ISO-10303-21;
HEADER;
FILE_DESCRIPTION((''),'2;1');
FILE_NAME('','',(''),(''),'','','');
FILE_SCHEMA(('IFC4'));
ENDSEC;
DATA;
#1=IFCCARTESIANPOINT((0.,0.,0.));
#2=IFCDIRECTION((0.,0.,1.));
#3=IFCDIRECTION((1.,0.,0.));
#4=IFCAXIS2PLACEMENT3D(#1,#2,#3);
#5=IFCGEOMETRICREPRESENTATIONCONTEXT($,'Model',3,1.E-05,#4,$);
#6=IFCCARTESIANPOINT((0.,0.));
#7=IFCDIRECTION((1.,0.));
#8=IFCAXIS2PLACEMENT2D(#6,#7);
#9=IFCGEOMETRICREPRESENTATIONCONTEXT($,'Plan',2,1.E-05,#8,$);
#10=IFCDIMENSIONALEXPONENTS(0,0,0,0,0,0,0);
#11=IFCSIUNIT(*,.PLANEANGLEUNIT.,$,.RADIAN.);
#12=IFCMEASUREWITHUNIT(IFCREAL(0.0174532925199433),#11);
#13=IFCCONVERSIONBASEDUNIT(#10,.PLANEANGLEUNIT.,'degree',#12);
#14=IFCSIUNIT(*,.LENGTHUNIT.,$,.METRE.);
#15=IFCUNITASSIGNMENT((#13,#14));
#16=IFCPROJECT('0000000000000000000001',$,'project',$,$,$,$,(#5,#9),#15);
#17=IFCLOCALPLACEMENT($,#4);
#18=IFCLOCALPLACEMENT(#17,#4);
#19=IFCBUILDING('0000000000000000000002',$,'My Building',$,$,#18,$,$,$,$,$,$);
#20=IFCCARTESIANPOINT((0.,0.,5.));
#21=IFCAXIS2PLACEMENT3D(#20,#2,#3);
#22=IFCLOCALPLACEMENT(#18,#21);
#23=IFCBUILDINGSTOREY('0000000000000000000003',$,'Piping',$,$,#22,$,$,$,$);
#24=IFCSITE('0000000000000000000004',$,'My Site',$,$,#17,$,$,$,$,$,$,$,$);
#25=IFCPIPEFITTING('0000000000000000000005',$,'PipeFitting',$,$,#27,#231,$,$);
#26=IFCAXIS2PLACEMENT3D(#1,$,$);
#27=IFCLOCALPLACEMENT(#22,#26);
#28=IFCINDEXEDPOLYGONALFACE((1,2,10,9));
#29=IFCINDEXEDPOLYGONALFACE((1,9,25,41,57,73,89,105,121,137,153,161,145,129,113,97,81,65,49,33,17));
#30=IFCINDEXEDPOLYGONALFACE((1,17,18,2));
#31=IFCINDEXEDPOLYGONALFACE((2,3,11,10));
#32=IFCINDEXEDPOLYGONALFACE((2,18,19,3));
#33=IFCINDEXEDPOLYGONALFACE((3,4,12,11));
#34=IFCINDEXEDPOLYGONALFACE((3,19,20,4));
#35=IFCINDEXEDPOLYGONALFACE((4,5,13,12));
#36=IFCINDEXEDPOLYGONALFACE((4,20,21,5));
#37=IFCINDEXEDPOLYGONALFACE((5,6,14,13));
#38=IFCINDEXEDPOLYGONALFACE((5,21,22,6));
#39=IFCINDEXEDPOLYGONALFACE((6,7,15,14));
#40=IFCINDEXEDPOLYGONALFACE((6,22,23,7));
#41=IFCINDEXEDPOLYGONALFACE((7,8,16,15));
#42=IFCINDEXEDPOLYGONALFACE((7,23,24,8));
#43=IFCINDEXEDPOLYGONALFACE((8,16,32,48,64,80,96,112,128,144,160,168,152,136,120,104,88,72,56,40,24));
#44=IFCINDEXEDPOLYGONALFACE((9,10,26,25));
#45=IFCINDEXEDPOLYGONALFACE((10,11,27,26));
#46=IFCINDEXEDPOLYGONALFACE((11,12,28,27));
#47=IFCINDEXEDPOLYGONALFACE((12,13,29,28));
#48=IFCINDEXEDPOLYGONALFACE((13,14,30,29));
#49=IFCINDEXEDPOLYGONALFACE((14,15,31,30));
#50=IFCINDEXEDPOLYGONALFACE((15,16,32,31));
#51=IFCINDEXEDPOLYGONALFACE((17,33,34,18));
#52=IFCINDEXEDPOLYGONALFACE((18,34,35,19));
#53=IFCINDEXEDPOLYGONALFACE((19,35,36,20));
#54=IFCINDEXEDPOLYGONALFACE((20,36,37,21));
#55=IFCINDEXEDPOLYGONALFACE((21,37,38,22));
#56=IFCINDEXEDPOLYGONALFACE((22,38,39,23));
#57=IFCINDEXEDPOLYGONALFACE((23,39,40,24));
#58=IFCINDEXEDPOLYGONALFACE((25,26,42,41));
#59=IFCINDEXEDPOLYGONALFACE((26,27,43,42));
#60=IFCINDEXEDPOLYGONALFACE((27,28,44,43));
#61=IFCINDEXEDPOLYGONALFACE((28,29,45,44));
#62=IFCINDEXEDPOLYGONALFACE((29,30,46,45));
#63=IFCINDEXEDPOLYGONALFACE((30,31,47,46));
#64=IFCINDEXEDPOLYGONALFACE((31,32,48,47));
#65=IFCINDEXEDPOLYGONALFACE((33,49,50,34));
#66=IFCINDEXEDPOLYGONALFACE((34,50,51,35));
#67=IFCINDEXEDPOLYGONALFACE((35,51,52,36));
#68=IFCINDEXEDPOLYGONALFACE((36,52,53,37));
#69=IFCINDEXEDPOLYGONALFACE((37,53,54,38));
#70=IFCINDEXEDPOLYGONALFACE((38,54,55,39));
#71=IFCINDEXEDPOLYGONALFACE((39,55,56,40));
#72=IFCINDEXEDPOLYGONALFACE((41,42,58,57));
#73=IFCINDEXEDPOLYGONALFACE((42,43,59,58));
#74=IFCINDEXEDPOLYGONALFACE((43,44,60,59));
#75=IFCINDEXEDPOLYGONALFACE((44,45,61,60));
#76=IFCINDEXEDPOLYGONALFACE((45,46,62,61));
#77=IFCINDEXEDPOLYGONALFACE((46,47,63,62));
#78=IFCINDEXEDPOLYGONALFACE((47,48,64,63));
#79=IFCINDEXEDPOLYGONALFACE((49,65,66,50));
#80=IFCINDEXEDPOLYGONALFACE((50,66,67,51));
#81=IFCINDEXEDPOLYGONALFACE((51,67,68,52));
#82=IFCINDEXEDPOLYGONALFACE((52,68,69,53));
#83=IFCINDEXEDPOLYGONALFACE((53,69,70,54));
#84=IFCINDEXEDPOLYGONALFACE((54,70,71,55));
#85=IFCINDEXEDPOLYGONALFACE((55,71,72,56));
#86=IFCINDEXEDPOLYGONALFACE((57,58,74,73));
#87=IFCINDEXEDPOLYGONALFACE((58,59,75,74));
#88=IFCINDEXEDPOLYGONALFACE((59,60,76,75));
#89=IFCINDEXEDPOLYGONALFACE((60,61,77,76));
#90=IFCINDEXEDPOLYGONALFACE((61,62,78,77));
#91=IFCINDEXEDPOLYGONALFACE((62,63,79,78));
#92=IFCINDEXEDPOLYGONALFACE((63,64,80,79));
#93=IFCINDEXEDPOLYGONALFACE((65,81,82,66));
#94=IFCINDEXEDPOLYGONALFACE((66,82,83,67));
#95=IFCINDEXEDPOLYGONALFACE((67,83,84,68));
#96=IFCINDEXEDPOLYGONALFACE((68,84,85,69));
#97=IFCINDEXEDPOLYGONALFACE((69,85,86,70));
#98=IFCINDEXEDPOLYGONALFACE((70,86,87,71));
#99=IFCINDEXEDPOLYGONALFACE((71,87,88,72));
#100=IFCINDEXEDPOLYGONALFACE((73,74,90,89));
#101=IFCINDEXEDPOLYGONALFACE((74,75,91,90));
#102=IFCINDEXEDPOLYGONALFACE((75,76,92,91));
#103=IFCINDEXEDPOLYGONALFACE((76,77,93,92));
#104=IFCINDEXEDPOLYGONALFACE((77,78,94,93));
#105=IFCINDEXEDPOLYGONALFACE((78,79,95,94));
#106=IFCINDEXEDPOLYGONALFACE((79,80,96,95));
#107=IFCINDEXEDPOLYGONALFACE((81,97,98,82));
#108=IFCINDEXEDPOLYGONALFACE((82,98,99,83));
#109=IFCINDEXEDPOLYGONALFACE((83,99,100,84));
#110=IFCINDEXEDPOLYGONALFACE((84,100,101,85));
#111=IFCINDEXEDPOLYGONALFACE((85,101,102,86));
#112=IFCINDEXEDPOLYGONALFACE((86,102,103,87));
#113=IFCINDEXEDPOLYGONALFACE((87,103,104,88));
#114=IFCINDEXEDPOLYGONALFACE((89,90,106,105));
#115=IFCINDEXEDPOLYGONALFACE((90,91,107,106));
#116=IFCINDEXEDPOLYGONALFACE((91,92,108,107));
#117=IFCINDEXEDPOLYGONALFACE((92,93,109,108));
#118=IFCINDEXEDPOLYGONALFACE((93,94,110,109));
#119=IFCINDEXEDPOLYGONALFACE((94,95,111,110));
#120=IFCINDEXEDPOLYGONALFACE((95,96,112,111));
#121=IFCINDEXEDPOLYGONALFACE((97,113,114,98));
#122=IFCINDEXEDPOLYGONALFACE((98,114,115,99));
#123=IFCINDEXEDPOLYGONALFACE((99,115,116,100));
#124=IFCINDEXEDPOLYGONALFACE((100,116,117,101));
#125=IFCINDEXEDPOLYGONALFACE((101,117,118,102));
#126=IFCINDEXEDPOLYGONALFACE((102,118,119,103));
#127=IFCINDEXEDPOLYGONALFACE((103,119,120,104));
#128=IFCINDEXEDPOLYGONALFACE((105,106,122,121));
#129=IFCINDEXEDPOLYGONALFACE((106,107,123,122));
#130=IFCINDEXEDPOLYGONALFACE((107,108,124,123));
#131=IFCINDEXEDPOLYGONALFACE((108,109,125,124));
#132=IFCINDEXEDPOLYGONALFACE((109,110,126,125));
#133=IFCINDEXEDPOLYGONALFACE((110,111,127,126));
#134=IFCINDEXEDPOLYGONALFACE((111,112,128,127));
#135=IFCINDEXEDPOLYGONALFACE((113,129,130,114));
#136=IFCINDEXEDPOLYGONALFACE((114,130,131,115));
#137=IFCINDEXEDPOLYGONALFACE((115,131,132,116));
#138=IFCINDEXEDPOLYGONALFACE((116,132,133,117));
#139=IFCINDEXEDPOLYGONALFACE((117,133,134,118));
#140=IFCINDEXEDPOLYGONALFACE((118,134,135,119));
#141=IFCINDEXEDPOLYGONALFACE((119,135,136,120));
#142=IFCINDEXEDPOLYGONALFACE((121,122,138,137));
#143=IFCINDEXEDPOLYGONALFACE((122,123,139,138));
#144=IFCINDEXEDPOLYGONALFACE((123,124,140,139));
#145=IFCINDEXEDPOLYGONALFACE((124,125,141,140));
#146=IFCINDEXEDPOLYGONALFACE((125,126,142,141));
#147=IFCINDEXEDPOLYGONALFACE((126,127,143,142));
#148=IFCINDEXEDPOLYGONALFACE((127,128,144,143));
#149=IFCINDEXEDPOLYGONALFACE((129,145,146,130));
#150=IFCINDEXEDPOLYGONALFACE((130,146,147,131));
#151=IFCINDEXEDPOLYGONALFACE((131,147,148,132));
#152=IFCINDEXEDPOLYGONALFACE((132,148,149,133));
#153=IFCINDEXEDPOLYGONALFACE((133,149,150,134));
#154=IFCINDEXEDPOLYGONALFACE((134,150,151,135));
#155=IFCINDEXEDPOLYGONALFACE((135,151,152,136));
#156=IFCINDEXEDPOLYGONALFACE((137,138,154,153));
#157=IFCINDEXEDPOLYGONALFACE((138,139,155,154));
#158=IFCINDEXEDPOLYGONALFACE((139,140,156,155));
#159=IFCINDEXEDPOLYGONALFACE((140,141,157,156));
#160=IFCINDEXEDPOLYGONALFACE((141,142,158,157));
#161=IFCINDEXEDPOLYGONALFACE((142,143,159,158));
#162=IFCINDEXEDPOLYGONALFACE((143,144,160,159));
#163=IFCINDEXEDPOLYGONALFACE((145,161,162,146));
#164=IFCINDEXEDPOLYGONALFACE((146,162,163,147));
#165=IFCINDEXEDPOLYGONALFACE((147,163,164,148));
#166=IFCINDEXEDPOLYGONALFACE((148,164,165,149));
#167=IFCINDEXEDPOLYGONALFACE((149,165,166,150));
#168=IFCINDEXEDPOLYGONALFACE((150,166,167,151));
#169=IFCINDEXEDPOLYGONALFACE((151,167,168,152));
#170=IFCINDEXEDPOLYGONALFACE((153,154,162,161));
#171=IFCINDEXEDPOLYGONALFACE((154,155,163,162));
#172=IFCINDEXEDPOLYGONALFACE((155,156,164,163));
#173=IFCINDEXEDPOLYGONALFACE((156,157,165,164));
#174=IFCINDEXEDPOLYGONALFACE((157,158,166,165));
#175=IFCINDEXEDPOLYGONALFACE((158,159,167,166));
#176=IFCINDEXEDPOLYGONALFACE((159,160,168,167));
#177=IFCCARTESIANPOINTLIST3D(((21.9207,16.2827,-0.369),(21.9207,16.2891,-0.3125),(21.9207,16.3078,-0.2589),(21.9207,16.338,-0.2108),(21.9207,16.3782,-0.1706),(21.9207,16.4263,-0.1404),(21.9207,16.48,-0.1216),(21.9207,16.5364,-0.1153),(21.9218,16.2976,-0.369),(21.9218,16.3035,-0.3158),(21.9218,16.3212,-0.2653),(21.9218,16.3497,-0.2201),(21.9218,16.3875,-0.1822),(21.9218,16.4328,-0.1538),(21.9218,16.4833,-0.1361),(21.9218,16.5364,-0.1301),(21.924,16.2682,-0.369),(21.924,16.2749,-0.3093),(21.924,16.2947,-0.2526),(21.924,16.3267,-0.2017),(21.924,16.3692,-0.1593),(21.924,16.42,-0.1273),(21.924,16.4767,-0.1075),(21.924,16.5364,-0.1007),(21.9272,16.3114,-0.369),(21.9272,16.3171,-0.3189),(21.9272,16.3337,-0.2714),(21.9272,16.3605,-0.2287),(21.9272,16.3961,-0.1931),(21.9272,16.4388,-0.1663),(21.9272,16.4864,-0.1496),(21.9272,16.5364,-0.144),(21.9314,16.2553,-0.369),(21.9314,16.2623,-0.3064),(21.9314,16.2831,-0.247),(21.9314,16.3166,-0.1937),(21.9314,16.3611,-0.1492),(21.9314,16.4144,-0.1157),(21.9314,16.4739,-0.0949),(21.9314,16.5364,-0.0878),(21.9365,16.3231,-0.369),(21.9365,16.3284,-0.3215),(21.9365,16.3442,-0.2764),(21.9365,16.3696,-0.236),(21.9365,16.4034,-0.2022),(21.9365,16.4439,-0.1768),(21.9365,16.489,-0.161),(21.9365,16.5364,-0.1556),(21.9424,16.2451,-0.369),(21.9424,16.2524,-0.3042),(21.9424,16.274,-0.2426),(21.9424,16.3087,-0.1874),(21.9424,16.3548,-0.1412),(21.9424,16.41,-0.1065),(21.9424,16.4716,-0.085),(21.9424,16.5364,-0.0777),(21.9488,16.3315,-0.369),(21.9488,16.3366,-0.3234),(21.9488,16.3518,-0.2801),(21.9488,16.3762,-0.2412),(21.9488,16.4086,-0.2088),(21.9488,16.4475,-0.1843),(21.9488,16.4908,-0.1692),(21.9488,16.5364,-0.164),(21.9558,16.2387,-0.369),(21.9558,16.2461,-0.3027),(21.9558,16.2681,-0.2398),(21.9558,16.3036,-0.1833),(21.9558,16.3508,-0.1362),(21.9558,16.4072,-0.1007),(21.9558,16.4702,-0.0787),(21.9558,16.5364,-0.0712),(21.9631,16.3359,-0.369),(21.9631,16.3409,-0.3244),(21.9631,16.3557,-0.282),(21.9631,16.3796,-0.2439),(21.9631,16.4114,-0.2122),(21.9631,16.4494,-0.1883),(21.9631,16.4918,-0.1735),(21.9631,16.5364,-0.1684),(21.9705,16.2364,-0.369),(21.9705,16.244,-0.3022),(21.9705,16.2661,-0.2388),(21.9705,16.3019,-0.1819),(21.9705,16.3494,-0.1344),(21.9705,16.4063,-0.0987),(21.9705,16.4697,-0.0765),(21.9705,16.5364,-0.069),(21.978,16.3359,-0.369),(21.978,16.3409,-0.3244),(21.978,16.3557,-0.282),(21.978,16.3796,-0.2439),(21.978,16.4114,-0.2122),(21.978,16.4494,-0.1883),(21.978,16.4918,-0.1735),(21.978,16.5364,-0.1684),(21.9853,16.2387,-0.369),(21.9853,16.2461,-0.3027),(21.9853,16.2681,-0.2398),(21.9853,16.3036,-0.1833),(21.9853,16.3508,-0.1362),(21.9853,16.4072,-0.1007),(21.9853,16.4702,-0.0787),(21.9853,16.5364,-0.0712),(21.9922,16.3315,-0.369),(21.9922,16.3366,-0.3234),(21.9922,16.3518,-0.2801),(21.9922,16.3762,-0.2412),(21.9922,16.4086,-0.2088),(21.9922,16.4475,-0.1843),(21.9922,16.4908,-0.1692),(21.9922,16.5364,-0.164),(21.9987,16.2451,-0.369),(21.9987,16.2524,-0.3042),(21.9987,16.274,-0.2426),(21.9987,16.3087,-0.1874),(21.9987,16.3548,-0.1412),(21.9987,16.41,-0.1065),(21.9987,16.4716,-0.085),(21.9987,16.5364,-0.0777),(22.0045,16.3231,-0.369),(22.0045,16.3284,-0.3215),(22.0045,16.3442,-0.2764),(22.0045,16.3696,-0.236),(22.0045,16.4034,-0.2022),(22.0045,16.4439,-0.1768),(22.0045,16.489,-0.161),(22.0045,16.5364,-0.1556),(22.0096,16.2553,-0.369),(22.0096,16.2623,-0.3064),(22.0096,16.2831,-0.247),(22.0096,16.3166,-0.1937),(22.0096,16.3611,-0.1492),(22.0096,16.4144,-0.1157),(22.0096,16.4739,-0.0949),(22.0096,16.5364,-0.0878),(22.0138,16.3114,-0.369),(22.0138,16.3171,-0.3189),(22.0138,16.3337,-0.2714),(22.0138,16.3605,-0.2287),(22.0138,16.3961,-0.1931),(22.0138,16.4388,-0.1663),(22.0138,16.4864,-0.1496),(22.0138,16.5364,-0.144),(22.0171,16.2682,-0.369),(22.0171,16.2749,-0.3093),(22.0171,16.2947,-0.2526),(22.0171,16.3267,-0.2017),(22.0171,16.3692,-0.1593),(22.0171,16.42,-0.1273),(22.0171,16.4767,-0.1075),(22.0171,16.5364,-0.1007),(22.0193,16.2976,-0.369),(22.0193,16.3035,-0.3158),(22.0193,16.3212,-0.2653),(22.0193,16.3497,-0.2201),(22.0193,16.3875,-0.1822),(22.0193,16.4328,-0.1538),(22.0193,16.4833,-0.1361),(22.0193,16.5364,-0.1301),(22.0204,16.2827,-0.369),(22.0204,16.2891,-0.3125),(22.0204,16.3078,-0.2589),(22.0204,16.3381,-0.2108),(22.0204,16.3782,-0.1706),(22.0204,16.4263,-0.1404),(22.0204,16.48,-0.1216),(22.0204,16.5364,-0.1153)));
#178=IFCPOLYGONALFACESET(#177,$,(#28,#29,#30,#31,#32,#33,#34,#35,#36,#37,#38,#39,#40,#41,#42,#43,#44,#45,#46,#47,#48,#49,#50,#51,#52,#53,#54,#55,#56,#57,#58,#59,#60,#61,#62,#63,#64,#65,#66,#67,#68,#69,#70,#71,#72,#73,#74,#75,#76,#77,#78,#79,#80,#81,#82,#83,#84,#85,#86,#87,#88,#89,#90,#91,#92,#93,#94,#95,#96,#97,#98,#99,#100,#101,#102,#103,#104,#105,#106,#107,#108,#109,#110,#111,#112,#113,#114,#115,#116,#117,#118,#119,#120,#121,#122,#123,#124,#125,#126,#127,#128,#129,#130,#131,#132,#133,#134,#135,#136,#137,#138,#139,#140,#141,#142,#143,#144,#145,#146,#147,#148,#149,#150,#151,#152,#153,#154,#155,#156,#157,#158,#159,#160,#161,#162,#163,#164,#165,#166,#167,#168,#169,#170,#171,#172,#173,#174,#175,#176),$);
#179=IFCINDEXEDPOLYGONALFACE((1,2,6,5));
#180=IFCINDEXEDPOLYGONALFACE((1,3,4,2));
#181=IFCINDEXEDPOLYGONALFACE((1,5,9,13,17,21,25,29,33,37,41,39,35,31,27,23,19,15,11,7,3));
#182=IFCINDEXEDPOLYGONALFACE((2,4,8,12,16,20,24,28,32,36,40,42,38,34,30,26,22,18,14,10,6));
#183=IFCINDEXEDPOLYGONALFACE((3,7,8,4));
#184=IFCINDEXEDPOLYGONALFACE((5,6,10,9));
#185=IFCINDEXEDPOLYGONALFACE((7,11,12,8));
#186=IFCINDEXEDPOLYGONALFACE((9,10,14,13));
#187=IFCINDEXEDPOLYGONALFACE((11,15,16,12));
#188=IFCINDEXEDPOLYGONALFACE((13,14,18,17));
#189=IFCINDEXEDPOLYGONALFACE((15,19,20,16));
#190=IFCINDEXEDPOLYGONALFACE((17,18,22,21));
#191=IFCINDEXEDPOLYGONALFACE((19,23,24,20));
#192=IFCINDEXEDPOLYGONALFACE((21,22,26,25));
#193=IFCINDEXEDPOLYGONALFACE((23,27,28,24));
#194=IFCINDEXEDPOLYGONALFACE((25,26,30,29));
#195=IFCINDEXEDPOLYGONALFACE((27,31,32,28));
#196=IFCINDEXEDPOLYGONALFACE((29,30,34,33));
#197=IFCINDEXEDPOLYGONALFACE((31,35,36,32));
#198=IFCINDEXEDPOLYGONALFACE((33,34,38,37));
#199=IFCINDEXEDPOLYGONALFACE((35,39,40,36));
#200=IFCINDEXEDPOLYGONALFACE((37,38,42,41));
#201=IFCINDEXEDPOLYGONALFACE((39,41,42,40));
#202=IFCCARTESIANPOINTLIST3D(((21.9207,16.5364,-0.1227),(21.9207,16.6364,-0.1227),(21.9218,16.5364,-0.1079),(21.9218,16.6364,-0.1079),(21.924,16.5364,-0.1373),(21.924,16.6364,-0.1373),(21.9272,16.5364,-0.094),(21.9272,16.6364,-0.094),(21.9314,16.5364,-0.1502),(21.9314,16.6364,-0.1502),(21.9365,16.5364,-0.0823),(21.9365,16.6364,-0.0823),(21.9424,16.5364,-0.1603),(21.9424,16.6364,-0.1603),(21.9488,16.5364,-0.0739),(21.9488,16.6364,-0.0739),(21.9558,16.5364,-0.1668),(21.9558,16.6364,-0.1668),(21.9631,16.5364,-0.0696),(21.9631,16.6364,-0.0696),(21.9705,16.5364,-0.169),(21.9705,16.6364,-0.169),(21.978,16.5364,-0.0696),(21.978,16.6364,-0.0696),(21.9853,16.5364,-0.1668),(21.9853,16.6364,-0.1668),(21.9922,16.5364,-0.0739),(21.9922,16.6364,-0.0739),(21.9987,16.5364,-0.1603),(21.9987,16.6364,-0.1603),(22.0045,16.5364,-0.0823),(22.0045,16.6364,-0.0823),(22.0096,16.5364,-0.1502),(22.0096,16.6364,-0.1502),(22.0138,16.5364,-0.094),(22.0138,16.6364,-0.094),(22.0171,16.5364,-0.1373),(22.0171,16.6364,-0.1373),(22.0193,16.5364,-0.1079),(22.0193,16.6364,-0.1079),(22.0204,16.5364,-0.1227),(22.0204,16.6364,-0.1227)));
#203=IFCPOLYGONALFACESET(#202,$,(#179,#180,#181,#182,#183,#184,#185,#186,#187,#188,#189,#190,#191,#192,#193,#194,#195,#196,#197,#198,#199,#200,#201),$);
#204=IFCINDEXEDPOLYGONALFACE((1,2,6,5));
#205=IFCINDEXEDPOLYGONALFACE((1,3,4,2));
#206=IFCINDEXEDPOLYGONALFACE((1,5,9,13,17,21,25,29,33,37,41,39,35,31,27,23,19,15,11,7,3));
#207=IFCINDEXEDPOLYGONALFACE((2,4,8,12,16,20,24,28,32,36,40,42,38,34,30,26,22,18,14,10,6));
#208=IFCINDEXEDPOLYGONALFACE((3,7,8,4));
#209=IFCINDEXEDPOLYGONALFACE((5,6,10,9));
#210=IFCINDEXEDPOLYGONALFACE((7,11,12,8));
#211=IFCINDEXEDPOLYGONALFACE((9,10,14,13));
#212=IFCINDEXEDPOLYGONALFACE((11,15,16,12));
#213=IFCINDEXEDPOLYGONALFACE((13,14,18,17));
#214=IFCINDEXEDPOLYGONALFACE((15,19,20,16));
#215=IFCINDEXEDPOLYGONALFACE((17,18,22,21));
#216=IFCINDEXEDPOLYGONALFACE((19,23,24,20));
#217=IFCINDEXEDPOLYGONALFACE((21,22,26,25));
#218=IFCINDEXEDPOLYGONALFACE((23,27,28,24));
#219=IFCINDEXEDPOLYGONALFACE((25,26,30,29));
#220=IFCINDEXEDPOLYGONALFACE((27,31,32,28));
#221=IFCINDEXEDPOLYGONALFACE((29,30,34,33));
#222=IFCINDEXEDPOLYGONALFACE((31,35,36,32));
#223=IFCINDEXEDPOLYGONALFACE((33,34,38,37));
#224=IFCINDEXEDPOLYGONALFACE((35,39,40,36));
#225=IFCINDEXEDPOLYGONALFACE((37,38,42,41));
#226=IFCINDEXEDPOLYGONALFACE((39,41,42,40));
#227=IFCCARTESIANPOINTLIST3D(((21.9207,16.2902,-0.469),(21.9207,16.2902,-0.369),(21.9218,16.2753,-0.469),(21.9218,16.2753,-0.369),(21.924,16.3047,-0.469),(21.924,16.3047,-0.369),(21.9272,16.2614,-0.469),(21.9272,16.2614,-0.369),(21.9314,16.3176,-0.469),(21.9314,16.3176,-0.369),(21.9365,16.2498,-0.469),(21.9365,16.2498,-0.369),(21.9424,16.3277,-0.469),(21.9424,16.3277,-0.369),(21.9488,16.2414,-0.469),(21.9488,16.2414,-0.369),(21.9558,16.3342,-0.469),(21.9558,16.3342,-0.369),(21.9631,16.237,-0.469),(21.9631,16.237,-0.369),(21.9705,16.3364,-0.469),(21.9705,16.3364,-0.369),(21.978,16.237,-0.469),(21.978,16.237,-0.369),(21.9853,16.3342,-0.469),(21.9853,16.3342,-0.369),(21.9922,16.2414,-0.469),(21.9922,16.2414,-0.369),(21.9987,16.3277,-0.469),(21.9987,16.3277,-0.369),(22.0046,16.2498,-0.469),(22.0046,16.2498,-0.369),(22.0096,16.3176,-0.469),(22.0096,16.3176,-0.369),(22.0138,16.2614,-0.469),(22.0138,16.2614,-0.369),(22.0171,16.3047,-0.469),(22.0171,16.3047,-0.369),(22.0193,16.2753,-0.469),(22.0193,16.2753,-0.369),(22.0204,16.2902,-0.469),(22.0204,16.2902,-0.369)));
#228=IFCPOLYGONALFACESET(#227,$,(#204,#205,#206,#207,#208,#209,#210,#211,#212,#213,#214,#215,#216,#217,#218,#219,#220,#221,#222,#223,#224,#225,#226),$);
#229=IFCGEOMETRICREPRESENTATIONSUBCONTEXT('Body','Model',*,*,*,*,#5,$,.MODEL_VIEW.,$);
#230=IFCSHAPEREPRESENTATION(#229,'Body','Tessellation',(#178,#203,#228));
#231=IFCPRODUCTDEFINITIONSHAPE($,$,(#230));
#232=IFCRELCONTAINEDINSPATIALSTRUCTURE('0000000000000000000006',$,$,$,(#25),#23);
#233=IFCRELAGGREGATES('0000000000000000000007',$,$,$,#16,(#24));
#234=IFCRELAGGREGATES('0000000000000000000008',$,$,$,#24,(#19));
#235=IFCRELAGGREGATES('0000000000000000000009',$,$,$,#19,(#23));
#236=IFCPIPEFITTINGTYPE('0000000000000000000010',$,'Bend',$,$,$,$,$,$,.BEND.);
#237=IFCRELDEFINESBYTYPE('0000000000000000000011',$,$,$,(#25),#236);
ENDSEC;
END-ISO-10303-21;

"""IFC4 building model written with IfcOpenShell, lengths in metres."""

from ifc_helpers import new_model, entity, si_unit, converted_unit, frame, origin_with_axes, origin_2d_with_axis, place, context, subcontext, project, spatial, circle, extrude, source, transform, mapped, type_object, type_shapes, element, save


model = new_model("IFC4")

# Units and contexts
model_context = context("Model", 3, precision=1e-05, world=origin_with_axes())
plan_context = context("Plan", 2, precision=1e-05, world=origin_2d_with_axis())
body_context = subcontext(model_context, "Body", "Model", "MODEL_VIEW")
ifc_project = project(units=[converted_unit("PLANEANGLEUNIT", "degree", entity("IfcReal", 0.0174532925199433), si_unit("PLANEANGLEUNIT", "RADIAN"), dimensions=[0, 0, 0, 0, 0, 0, 0]), si_unit("LENGTHUNIT", "METRE")], contexts=[model_context, plan_context])

# Site, building, storey
site_placement = place(None, origin_with_axes())
site = spatial("IfcSite", under=ifc_project, at=site_placement, Name="My Site")
building_placement = place(site_placement, origin_with_axes())
building = spatial("IfcBuilding", under=site, at=building_placement, Name="My Building")
storey_placement = place(building_placement, frame((0.0, 0.0, 5.0), z_axis=(0.0, 0.0, 1.0), x_axis=(1.0, 0.0, 0.0)))
storey = spatial("IfcBuildingStorey", under=building, at=storey_placement, Name="Piping")

# Pipe fitting
pipe_fitting_type_1 = type_object("IfcPipeFittingType", Name="Bend", PredefinedType="BEND")
shared_shape = source(origin_with_axes(), body_context, "Body", "SolidModel", [
    entity("IfcSweptDiskSolid", entity("IfcIndexedPolyCurve", entity("IfcCartesianPointList3D", [[0.0, 0.0, -0.1], [0.0732, 0.0, -0.2768], [0.25, 0.0, -0.35]]), [entity("IfcArcIndex", [1, 2, 3])]), 0.05),
    extrude(circle(Radius=0.05), origin_with_axes(), (0.0, 0.0, -1.0), 0.1),
    extrude(circle(Radius=0.05), frame((0.25, 0.0, -0.35), z_axis=(1.0, 0.0, 0.0), x_axis=(0.0, 0.0, 1.0)), (0.0, 0.0, 1.0), 0.1),
])
type_shapes(pipe_fitting_type_1, [shared_shape])
for number, where, z_axis, x_axis, name in (
    (1, (21.9705, 16.6364, -0.119), (-0.00006, 1.0, 0.0), (0.0, 0.0, -1.0), "PipeFitting"),
):
    element("IfcPipeFitting", number, at=place(storey_placement, frame(where, z_axis=z_axis, x_axis=x_axis)), inside=storey, type_object=pipe_fitting_type_1, Name=name, context=body_context, shape_type="MappedRepresentation", body=[
        mapped(shared_shape, transform((0.0, 0.0, 0.0), x_axis=(1.0, 0.0, 0.0), y_axis=(0.0, 1.0, 0.0), z_axis=(0.0, 0.0, 1.0), scale=1.0)),
    ])

save(model, "model.ifc")
